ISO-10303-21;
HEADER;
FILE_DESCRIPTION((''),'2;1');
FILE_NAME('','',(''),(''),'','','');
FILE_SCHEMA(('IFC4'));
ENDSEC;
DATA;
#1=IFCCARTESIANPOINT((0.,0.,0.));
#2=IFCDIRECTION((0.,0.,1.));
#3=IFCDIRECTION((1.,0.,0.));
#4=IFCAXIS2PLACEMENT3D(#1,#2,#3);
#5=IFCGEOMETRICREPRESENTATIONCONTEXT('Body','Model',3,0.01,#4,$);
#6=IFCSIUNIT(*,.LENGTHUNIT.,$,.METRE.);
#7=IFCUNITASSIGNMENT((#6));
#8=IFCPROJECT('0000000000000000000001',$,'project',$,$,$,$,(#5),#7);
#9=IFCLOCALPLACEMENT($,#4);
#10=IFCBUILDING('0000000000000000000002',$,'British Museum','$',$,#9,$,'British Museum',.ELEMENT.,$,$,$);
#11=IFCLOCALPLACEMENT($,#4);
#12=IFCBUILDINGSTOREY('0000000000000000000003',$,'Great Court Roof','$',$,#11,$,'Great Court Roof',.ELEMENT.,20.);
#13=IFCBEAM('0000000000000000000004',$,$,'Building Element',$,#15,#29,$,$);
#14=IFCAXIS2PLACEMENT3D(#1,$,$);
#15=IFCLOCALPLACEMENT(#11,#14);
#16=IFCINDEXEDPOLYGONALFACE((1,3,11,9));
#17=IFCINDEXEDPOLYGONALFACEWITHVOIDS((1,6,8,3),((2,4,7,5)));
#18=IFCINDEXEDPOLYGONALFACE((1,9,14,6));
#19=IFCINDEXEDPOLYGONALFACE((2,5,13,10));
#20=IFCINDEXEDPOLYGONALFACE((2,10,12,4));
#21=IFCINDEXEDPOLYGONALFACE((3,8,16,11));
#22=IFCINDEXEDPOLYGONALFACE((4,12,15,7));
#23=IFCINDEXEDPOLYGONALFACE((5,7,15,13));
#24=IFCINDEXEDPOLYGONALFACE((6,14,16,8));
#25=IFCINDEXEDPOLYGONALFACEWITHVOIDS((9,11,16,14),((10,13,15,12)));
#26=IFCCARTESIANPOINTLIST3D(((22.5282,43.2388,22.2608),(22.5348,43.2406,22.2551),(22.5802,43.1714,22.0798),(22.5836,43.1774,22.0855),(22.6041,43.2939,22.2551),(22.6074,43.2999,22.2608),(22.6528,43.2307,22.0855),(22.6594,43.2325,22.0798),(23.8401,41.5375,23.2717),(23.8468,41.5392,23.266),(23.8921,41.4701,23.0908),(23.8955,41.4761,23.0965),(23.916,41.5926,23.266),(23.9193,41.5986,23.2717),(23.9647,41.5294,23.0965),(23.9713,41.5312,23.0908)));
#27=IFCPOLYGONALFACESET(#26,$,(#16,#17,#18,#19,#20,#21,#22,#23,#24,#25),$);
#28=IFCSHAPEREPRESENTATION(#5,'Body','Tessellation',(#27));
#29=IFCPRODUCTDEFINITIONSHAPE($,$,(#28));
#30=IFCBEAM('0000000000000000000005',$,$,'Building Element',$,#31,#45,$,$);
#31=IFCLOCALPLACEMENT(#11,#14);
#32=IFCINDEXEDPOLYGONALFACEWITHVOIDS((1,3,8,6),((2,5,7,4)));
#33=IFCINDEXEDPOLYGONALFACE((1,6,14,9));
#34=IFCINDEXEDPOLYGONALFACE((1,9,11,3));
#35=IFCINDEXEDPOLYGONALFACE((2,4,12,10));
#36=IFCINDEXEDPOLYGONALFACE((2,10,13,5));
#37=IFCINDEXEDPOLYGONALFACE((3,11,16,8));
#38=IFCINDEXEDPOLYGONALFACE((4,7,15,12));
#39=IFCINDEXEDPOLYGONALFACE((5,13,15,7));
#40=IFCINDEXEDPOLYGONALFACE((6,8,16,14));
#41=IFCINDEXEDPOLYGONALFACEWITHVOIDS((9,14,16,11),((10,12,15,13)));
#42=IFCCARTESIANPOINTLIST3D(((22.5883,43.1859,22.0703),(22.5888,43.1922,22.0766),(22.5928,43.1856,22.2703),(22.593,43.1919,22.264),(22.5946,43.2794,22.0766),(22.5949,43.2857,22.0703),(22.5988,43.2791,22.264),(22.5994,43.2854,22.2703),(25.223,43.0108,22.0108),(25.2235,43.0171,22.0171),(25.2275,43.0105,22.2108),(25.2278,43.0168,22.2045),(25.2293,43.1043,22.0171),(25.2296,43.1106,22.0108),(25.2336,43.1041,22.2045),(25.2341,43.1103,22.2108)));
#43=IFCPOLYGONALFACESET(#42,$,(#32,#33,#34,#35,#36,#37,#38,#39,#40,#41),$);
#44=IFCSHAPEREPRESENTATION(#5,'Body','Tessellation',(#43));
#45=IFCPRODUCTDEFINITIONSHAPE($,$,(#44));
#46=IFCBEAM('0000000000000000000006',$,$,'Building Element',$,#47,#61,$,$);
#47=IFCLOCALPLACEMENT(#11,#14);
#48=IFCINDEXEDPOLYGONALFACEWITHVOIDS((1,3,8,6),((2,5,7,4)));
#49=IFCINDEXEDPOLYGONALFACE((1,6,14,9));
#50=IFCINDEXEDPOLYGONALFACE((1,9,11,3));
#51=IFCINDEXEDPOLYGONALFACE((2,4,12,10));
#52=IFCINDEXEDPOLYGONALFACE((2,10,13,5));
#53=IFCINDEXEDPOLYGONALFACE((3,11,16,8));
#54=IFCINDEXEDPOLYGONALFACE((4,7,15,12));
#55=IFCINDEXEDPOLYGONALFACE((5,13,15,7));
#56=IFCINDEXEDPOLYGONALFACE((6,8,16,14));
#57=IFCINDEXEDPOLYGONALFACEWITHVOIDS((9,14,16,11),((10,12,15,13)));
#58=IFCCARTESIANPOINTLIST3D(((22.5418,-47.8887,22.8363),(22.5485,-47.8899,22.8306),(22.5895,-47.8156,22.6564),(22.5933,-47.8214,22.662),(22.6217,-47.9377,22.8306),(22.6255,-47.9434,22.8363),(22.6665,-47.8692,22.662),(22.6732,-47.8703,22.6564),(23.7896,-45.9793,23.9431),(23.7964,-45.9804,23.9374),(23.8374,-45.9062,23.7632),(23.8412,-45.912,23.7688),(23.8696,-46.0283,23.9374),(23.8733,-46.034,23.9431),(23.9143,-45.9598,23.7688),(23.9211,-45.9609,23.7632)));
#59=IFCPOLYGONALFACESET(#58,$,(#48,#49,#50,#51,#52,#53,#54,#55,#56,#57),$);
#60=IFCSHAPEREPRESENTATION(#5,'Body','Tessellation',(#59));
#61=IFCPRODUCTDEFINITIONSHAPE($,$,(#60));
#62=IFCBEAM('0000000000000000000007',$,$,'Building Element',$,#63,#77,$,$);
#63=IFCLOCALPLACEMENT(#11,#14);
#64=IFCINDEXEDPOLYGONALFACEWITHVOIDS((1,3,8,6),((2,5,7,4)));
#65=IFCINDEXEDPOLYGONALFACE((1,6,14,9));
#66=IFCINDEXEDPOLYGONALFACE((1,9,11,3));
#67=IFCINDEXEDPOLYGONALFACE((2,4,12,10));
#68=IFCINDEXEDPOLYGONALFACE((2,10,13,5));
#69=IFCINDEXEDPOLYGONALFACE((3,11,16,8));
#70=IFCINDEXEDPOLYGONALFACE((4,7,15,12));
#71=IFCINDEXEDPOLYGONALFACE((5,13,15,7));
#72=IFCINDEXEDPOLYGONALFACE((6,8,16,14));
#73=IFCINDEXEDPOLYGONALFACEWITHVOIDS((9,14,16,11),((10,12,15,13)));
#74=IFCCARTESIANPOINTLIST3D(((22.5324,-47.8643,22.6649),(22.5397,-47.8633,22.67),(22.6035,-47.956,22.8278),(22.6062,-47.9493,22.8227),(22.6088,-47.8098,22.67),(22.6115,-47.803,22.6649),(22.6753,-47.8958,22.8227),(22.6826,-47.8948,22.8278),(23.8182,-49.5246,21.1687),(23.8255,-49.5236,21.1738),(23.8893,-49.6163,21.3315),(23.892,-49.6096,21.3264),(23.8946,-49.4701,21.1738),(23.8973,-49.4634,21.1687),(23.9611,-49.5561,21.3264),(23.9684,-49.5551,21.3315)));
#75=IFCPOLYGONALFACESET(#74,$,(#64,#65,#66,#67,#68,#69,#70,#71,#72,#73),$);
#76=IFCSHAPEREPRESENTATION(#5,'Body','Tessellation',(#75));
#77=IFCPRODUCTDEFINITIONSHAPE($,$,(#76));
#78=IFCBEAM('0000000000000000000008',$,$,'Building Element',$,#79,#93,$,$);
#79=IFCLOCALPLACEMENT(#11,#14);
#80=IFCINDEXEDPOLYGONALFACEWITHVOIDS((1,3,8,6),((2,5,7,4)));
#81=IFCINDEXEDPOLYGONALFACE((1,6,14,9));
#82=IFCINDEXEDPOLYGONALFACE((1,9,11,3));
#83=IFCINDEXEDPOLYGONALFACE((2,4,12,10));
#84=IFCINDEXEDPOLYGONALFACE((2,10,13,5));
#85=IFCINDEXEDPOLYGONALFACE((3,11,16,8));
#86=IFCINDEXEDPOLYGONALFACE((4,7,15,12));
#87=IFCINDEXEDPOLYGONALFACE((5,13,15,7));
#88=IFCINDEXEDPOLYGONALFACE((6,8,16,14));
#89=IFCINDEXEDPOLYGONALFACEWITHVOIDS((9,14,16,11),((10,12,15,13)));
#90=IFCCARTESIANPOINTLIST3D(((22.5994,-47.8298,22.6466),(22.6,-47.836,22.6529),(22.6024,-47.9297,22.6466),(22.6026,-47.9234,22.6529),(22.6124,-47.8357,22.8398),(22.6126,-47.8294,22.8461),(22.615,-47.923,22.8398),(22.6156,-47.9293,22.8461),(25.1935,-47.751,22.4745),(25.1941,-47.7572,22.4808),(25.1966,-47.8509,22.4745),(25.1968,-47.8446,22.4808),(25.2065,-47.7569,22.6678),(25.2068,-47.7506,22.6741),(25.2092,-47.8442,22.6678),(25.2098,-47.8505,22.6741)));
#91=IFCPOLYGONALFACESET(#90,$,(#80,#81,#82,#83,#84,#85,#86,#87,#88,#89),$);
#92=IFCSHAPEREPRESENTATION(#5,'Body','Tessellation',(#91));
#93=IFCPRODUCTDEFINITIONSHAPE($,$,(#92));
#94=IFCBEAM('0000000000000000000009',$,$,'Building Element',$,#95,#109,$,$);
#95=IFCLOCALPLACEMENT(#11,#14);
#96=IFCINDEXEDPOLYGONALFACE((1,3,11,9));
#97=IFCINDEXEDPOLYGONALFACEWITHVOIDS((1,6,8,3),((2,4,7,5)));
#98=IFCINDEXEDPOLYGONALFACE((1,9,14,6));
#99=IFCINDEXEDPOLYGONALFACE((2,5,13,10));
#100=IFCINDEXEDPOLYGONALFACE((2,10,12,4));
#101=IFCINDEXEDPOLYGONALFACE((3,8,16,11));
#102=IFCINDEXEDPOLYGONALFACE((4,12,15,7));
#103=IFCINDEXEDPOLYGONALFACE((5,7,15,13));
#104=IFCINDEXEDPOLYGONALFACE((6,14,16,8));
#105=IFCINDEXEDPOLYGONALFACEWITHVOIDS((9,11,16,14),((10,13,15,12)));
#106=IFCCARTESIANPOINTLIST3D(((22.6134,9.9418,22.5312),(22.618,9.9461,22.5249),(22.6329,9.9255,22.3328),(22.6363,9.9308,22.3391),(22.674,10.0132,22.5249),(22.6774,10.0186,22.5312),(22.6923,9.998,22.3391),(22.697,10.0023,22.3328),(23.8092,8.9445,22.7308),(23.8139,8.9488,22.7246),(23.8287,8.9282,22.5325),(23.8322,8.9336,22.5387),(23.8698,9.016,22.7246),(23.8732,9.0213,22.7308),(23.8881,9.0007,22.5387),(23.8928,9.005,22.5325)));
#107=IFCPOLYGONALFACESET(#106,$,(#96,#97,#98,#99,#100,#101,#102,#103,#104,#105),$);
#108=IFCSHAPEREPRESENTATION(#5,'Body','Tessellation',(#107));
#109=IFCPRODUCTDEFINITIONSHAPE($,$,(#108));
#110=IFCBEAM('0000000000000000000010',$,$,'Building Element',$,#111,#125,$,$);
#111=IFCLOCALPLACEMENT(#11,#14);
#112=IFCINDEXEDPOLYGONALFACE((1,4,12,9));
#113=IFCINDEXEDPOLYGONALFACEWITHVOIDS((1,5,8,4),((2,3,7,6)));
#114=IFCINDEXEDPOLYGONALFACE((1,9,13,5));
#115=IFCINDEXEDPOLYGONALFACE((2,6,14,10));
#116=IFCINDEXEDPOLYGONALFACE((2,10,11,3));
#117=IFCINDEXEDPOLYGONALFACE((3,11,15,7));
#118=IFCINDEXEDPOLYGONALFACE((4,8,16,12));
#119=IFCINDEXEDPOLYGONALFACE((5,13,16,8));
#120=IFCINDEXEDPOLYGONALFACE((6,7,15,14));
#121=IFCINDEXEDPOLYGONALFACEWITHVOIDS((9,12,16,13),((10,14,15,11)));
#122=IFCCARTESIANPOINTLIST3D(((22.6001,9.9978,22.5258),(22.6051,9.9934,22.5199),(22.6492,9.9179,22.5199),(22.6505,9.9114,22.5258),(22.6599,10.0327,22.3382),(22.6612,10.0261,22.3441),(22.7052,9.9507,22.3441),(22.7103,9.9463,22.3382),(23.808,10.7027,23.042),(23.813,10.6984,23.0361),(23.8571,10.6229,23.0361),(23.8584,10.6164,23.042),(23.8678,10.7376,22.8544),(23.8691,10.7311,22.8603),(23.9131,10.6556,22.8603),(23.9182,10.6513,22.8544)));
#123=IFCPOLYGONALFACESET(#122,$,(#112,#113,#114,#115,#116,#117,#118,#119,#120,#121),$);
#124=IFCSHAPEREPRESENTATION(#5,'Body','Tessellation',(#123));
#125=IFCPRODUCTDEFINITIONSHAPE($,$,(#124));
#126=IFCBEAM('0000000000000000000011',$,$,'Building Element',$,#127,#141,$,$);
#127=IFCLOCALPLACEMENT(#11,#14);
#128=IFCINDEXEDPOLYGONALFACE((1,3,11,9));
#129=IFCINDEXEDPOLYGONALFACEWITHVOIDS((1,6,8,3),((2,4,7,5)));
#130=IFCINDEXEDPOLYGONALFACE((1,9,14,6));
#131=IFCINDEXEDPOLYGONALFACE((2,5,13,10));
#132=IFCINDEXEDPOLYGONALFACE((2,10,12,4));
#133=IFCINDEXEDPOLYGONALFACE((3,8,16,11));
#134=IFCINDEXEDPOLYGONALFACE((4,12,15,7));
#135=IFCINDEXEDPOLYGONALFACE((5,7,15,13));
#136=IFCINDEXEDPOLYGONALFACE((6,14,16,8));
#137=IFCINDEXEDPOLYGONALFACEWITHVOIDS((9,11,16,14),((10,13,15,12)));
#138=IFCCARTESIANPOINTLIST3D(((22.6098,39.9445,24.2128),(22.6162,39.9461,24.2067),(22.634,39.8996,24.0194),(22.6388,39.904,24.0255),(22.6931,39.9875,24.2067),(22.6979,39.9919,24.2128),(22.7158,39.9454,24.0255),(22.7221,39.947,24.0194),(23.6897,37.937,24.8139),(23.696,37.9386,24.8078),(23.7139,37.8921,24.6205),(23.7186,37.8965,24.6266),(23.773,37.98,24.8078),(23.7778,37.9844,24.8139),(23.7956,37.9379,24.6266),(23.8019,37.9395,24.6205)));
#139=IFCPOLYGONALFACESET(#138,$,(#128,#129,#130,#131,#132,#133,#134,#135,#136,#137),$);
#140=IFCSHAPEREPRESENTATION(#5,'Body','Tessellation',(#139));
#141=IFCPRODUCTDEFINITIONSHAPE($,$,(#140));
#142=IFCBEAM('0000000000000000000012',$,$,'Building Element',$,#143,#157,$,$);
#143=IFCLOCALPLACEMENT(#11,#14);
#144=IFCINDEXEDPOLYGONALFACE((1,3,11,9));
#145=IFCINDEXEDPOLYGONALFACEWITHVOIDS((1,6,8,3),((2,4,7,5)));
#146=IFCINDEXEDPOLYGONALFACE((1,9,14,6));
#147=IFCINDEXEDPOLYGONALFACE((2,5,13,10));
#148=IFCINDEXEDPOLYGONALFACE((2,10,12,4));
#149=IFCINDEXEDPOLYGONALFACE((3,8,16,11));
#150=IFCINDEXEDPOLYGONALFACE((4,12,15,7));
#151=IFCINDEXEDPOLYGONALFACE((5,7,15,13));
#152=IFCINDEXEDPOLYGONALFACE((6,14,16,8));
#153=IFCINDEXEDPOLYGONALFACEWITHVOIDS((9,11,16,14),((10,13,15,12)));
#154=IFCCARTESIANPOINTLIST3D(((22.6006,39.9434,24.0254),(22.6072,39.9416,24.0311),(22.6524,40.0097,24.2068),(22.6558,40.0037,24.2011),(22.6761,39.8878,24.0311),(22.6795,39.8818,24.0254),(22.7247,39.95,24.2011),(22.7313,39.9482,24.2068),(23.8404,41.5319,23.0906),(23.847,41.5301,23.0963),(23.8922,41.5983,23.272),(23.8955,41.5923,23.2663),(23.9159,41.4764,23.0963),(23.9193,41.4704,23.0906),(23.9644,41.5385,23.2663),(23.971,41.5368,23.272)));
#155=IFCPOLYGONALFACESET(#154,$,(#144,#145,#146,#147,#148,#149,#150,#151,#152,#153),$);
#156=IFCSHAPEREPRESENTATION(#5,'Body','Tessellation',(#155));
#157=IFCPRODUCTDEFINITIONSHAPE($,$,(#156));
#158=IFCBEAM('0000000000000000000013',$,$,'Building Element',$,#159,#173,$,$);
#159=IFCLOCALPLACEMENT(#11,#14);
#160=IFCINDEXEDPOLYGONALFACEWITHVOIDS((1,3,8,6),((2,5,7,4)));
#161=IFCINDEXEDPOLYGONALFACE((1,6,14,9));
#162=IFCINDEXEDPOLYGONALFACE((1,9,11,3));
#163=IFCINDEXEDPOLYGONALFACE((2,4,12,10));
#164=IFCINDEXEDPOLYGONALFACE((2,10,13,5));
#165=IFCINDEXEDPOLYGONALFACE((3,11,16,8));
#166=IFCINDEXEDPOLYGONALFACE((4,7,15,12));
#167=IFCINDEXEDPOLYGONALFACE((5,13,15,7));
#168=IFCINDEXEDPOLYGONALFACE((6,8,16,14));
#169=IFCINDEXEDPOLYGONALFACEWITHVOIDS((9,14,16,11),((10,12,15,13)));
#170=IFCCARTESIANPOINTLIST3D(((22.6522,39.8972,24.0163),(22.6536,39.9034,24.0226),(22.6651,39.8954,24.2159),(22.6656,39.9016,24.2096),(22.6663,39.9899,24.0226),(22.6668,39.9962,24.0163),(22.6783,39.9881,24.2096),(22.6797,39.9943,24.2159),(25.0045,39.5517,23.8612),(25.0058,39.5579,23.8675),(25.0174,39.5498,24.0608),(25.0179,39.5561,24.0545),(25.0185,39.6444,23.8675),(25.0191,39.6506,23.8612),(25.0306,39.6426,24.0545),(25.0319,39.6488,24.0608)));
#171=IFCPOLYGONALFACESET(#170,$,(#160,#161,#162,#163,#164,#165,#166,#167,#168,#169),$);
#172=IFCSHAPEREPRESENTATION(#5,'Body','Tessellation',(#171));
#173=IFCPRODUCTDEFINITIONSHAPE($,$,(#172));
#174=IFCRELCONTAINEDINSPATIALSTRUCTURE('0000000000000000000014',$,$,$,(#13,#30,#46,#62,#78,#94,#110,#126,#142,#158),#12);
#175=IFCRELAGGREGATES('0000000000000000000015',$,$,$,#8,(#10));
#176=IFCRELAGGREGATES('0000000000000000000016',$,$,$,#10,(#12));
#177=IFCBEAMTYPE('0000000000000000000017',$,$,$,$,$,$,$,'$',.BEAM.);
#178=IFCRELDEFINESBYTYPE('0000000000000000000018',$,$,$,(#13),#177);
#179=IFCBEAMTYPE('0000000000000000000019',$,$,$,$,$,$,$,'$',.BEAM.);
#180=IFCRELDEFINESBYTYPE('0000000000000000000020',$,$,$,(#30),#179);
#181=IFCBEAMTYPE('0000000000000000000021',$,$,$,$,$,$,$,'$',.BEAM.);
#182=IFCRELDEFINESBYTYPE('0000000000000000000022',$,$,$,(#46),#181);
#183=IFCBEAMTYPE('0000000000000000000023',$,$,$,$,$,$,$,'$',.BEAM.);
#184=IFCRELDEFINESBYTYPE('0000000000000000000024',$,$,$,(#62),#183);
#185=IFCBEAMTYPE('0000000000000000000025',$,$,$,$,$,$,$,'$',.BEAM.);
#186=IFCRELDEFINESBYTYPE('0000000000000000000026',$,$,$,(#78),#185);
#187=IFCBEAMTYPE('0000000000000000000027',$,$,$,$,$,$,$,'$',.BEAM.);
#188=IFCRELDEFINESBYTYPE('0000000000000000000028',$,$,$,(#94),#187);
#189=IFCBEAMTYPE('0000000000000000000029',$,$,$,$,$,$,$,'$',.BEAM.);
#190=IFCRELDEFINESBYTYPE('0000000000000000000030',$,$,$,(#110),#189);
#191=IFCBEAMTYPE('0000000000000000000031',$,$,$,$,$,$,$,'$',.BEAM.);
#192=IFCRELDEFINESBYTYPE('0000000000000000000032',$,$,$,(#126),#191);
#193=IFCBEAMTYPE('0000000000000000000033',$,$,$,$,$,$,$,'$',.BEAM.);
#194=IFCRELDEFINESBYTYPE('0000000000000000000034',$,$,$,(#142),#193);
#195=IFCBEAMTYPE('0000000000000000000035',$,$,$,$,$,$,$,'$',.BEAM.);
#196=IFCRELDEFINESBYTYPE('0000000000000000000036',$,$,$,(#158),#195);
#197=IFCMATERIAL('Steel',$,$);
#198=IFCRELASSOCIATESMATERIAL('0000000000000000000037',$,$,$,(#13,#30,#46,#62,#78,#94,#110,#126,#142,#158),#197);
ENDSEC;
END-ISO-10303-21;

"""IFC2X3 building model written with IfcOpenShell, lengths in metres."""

from ifc_helpers import new_model, si_unit, frame, origin_with_axes, origin_2d, place, context, project, spatial, hollow_rectangle, extrude, material, type_object, element, save


model = new_model("IFC2X3")

# Units and contexts
model_context = context("Model", 3, precision=0.01, world=origin_with_axes(), identifier="Body")
ifc_project = project(units=[si_unit("LENGTHUNIT", "METRE")], contexts=[model_context])

# Building, storey
building_placement = place(None, origin_with_axes())
building = spatial("IfcBuilding", under=ifc_project, at=building_placement, Name="British Museum", Description="$", LongName="British Museum", CompositionType="ELEMENT")
storey_placement = place(None, origin_with_axes())
storey = spatial("IfcBuildingStorey", under=building, at=storey_placement, Name="Great Court Roof", Description="$", LongName="Great Court Roof", CompositionType="ELEMENT", Elevation=20.0)

# Beams
ifc_material = material(Name="Steel")
beam_type_1 = type_object("IfcBeamType", ElementType="$", PredefinedType="BEAM")
beam_1_placement = place(None, origin_with_axes())
element("IfcBeam", 1, at=beam_1_placement, inside=storey, type_object=beam_type_1, material=ifc_material, Description="Building Element", context=model_context, shape_type="SweptSolid", body=[
    extrude(hollow_rectangle(XDim=0.1, YDim=0.2, WallThickness=0.0063, InnerFilletRadius=-0.0063, OuterFilletRadius=0.0, at=origin_2d()), frame((22.5938, 43.2356, 22.1703), z_axis=(0.552528, -0.71653, 0.42579), x_axis=(0.791902, 0.610648, 0.0)), (0.0, 0.0, 1.0), 2.3744),
])
beam_type_2 = type_object("IfcBeamType", ElementType="$", PredefinedType="BEAM")
beam_2_placement = place(None, origin_with_axes())
element("IfcBeam", 2, at=beam_2_placement, inside=storey, type_object=beam_type_2, material=ifc_material, Description="Building Element", context=model_context, shape_type="SweptSolid", body=[
    extrude(hollow_rectangle(XDim=0.1, YDim=0.2, WallThickness=0.0063, InnerFilletRadius=-0.0063, OuterFilletRadius=0.0, at=origin_2d()), frame((22.5938, 43.2356, 22.1703), z_axis=(0.997547, -0.06628, -0.022529), x_axis=(0.066297, 0.9978, 0.0)), (0.0, 0.0, 1.0), 2.6412),
])
beam_type_3 = type_object("IfcBeamType", ElementType="$", PredefinedType="BEAM")
beam_3_placement = place(None, origin_with_axes())
element("IfcBeam", 3, at=beam_3_placement, inside=storey, type_object=beam_type_3, material=ifc_material, Description="Building Element", context=model_context, shape_type="SweptSolid", body=[
    extrude(hollow_rectangle(XDim=0.1, YDim=0.2, WallThickness=0.0063, InnerFilletRadius=-0.0063, OuterFilletRadius=0.0, at=origin_2d()), frame((22.6075, -47.8795, 22.7463), z_axis=(0.492185, 0.753115, 0.436545), x_axis=(-0.83709, 0.547065, 0.0)), (0.0, 0.0, 1.0), 2.5354),
])
beam_type_4 = type_object("IfcBeamType", ElementType="$", PredefinedType="BEAM")
beam_4_placement = place(None, origin_with_axes())
element("IfcBeam", 4, at=beam_4_placement, inside=storey, type_object=beam_type_4, material=ifc_material, Description="Building Element", context=model_context, shape_type="SweptSolid", body=[
    extrude(hollow_rectangle(XDim=0.1, YDim=0.2, WallThickness=0.0063, InnerFilletRadius=-0.0063, OuterFilletRadius=0.0, at=origin_2d()), frame((22.6075, -47.8795, 22.7463), z_axis=(0.498661, -0.643906, -0.580279), x_axis=(0.790633, 0.612291, 0.0)), (0.0, 0.0, 1.0), 2.5785),
])
beam_type_5 = type_object("IfcBeamType", ElementType="$", PredefinedType="BEAM")
beam_5_placement = place(None, origin_with_axes())
element("IfcBeam", 5, at=beam_5_placement, inside=storey, type_object=beam_type_5, material=ifc_material, Description="Building Element", context=model_context, shape_type="SweptSolid", body=[
    extrude(hollow_rectangle(XDim=0.1, YDim=0.2, WallThickness=0.0063, InnerFilletRadius=-0.0063, OuterFilletRadius=0.0, at=origin_2d()), frame((22.6075, -47.8795, 22.7463), z_axis=(0.99735, 0.030298, -0.066151), x_axis=(-0.030364, 0.999539, 0.0)), (0.0, 0.0, 1.0), 2.6011),
])
beam_type_6 = type_object("IfcBeamType", ElementType="$", PredefinedType="BEAM")
beam_6_placement = place(None, origin_with_axes())
element("IfcBeam", 6, at=beam_6_placement, inside=storey, type_object=beam_type_6, material=ifc_material, Description="Building Element", context=model_context, shape_type="SweptSolid", body=[
    extrude(hollow_rectangle(XDim=0.1, YDim=0.2, WallThickness=0.0063, InnerFilletRadius=-0.0063, OuterFilletRadius=0.0, at=origin_2d()), frame((22.6552, 9.972, 22.432), z_axis=(0.761747, -0.63527, 0.127177), x_axis=(0.64047, 0.767983, 0.0)), (0.0, 0.0, 1.0), 1.5698),
])
beam_type_7 = type_object("IfcBeamType", ElementType="$", PredefinedType="BEAM")
beam_7_placement = place(None, origin_with_axes())
element("IfcBeam", 7, at=beam_7_placement, inside=storey, type_object=beam_type_7, material=ifc_material, Description="Building Element", context=model_context, shape_type="SweptSolid", body=[
    extrude(hollow_rectangle(XDim=0.1, YDim=0.2, WallThickness=0.0063, InnerFilletRadius=-0.0063, OuterFilletRadius=0.0, at=origin_2d()), frame((22.6552, 9.972, 22.432), z_axis=(0.810244, 0.472868, 0.346267), x_axis=(-0.50405, 0.863674, 0.0)), (0.0, 0.0, 1.0), 1.4908),
])
beam_type_8 = type_object("IfcBeamType", ElementType="$", PredefinedType="BEAM")
beam_8_placement = place(None, origin_with_axes())
element("IfcBeam", 8, at=beam_8_placement, inside=storey, type_object=beam_type_8, material=ifc_material, Description="Building Element", context=model_context, shape_type="SweptSolid", body=[
    extrude(hollow_rectangle(XDim=0.1, YDim=0.2, WallThickness=0.0063, InnerFilletRadius=-0.0063, OuterFilletRadius=0.0, at=origin_2d()), frame((22.666, 39.9458, 24.1161), z_axis=(0.458062, -0.851564, 0.254986), x_axis=(0.880675, 0.473721, 0.0)), (0.0, 0.0, 1.0), 2.3574),
])
beam_type_9 = type_object("IfcBeamType", ElementType="$", PredefinedType="BEAM")
beam_9_placement = place(None, origin_with_axes())
element("IfcBeam", 9, at=beam_9_placement, inside=storey, type_object=beam_type_9, material=ifc_material, Description="Building Element", context=model_context, shape_type="SweptSolid", body=[
    extrude(hollow_rectangle(XDim=0.1, YDim=0.2, WallThickness=0.0063, InnerFilletRadius=-0.0063, OuterFilletRadius=0.0, at=origin_2d()), frame((22.666, 39.9458, 24.1161), z_axis=(0.558108, 0.715126, -0.420845), x_axis=(-0.788337, 0.615244, 0.0)), (0.0, 0.0, 1.0), 2.2214),
])
beam_type_10 = type_object("IfcBeamType", ElementType="$", PredefinedType="BEAM")
beam_10_placement = place(None, origin_with_axes())
element("IfcBeam", 10, at=beam_10_placement, inside=storey, type_object=beam_type_10, material=ifc_material, Description="Building Element", context=model_context, shape_type="SweptSolid", body=[
    extrude(hollow_rectangle(XDim=0.1, YDim=0.2, WallThickness=0.0063, InnerFilletRadius=-0.0063, OuterFilletRadius=0.0, at=origin_2d()), frame((22.666, 39.9458, 24.1161), z_axis=(0.987283, -0.145026, -0.065107), x_axis=(0.145334, 0.989383, 0.0)), (0.0, 0.0, 1.0), 2.3826),
])

save(model, "model.ifc")
